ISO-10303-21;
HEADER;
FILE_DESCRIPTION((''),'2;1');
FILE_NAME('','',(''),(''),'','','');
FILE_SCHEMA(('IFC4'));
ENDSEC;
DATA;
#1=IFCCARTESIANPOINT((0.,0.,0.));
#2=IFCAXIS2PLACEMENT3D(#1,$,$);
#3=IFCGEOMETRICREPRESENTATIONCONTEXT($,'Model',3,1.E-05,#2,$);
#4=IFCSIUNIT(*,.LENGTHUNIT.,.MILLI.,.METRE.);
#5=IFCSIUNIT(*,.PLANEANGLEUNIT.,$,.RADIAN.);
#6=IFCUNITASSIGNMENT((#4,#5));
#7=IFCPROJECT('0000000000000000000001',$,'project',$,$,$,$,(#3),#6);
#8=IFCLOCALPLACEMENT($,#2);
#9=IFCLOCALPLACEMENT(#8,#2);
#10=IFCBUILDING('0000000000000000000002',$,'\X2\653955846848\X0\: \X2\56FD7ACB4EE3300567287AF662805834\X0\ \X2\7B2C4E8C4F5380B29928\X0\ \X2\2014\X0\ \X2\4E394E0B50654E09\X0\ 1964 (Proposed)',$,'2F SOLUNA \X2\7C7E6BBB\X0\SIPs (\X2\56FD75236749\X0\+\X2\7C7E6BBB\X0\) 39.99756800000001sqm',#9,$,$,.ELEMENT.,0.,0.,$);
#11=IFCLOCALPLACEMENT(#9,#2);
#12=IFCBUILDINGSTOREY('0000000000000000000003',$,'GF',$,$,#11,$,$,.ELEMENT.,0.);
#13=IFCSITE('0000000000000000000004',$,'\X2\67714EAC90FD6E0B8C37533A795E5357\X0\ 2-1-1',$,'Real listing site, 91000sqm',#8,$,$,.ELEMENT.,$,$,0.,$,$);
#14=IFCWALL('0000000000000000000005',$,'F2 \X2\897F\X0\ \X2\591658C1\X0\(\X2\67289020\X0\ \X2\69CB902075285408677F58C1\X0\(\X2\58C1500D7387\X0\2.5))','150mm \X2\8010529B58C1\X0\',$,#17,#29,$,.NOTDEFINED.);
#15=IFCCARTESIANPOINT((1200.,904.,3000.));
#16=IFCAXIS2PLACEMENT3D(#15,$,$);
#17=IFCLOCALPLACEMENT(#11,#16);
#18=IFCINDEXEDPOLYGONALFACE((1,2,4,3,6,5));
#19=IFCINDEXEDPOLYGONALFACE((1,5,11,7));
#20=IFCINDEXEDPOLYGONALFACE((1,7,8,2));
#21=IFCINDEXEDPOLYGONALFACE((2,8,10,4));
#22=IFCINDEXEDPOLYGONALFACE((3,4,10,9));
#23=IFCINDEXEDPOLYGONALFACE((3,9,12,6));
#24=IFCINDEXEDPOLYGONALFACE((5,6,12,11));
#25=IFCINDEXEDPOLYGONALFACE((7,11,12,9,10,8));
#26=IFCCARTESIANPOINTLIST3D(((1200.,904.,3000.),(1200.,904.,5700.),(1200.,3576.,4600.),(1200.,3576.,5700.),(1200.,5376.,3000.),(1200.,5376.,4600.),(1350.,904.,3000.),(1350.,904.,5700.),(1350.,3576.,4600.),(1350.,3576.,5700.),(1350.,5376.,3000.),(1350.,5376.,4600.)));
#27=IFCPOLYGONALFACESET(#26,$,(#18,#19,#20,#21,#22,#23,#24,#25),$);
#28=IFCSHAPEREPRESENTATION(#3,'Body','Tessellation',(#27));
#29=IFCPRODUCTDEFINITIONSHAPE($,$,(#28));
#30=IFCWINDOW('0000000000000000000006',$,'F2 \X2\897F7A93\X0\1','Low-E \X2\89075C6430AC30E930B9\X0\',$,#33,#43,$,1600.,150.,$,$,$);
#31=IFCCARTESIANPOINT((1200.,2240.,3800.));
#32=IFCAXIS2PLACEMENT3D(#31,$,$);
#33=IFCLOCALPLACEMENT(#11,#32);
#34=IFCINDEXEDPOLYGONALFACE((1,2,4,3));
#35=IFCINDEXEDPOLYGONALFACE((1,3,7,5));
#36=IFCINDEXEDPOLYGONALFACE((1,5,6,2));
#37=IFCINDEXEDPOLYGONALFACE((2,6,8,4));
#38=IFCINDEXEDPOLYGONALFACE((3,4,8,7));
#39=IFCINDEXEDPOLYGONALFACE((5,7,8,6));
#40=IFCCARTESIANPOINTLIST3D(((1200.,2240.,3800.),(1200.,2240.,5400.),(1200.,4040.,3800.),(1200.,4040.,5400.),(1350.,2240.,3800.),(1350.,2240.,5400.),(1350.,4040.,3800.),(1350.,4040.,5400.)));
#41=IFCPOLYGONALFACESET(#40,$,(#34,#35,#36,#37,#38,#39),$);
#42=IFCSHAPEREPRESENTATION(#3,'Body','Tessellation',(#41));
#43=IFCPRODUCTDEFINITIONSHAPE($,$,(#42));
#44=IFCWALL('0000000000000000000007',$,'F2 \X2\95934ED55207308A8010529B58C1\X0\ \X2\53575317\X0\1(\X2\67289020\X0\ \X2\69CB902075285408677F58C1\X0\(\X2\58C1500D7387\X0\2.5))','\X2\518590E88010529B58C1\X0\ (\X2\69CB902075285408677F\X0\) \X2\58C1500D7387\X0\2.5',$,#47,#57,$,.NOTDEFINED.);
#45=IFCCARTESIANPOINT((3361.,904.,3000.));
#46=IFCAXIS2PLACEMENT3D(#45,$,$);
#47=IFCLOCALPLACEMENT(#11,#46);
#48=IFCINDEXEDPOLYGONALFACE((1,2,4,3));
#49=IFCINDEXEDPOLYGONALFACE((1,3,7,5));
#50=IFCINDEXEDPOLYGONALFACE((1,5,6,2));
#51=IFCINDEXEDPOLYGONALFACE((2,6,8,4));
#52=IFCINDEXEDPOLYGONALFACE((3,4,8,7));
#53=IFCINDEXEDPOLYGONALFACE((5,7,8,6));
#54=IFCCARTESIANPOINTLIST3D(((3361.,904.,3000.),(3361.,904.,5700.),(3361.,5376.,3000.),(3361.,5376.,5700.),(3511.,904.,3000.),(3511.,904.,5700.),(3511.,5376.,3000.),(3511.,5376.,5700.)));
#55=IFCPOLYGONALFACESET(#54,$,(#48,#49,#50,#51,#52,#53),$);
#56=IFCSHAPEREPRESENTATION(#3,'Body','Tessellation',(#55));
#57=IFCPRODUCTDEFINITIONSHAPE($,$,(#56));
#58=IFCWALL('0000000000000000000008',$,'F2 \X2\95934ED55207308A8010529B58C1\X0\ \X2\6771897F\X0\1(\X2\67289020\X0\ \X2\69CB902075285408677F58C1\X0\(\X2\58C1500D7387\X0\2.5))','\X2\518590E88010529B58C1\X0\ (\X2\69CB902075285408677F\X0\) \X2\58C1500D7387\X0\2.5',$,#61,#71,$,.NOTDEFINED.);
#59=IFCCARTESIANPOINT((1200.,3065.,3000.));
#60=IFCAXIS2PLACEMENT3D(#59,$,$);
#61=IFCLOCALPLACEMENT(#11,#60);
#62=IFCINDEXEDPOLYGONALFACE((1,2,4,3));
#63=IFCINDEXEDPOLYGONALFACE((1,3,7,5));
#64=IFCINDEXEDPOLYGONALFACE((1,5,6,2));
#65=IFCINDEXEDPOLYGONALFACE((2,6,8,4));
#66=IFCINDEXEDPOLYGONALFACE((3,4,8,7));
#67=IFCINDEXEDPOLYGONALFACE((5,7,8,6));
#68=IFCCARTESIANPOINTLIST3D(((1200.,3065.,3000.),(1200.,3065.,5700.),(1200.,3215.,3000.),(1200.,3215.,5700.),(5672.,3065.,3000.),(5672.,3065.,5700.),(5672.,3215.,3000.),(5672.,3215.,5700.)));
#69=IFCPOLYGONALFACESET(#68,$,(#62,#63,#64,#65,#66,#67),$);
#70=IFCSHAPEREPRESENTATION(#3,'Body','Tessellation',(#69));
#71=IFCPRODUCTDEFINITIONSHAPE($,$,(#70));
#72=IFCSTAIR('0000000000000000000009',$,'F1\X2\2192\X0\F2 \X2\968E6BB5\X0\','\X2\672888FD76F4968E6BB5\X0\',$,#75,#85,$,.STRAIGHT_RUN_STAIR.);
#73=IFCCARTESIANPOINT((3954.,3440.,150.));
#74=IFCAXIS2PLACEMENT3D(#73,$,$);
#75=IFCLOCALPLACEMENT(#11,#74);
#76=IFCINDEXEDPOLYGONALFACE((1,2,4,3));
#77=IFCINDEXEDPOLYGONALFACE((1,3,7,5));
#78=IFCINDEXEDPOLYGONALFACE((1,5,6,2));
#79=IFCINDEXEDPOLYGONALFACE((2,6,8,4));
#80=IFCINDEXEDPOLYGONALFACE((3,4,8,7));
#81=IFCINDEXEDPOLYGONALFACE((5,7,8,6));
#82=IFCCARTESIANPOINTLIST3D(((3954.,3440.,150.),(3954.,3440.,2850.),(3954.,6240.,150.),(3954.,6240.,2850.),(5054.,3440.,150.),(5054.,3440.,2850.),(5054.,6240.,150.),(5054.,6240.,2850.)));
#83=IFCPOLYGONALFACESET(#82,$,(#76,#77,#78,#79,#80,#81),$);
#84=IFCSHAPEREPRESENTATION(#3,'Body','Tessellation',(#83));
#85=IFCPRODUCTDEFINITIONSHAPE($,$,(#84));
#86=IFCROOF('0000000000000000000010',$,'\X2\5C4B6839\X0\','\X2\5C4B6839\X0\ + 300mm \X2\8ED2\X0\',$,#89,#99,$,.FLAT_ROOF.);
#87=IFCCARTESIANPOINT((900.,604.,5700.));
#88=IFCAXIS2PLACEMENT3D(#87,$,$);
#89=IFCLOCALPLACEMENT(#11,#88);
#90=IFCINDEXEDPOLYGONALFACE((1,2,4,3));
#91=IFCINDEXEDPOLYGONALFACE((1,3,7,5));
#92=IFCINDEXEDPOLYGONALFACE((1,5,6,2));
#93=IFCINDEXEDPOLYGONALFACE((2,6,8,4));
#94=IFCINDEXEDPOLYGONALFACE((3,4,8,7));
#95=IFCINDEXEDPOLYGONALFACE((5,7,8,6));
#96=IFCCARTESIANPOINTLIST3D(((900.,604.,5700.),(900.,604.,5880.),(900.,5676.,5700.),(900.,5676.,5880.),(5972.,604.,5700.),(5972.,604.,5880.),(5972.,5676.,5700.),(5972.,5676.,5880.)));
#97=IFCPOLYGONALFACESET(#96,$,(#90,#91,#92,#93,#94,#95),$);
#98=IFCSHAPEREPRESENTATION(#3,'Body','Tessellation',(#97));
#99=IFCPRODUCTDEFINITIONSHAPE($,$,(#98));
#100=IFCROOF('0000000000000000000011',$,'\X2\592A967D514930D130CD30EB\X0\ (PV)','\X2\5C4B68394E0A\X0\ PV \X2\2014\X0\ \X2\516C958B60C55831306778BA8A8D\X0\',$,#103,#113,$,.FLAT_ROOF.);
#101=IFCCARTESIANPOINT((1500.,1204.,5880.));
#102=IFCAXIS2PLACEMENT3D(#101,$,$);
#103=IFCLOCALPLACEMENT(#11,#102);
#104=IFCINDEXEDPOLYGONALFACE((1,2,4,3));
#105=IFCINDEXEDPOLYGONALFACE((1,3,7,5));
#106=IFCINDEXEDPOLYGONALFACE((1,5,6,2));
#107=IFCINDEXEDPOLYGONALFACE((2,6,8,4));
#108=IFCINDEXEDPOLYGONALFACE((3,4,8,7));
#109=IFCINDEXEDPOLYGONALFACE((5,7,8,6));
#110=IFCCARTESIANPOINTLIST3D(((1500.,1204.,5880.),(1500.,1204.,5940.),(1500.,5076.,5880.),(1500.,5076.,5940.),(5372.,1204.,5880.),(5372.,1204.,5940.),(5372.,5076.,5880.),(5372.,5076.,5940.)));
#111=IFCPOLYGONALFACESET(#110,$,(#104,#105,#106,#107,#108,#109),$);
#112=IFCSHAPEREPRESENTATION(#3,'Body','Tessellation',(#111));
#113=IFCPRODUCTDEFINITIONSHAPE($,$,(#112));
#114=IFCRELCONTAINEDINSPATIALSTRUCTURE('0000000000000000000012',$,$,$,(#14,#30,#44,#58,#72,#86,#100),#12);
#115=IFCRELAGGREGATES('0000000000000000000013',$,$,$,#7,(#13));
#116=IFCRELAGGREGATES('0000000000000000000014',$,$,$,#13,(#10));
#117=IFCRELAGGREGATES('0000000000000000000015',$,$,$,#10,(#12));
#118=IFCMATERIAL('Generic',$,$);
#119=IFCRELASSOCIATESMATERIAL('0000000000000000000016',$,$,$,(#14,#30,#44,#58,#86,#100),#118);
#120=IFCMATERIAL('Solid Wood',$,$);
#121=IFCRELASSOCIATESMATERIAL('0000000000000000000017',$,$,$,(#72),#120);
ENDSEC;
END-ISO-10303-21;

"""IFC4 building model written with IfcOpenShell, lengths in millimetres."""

from ifc_helpers import new_model, si_unit, frame, frame_2d, origin, place, context, project, spatial, rectangle, extrude, material, element, fill, save


model = new_model("IFC4")

# Units and contexts
model_context = context("Model", 3, precision=1e-05, world=origin())
ifc_project = project(units=[si_unit("LENGTHUNIT", "METRE", prefix="MILLI"), si_unit("PLANEANGLEUNIT", "RADIAN")], contexts=[model_context])

# Site, building, storey
site_placement = place(None, origin())
site = spatial("IfcSite", under=ifc_project, at=site_placement, Name="東京都渋谷区神南 2-1-1", ObjectType="Real listing site, 91000sqm", CompositionType="ELEMENT", RefElevation=0.0)
building_placement = place(site_placement, origin())
building = spatial("IfcBuilding", under=site, at=building_placement, Name="改善案: 国立代々木競技場 第二体育館 — 丹下健三 1964 (Proposed)", ObjectType="2F SOLUNA 籾殻SIPs (国産杉+籾殻) 39.99756800000001sqm", CompositionType="ELEMENT", ElevationOfRefHeight=0.0, ElevationOfTerrain=0.0)
storey_placement = place(building_placement, origin())
storey = spatial("IfcBuildingStorey", under=building, at=storey_placement, Name="GF", CompositionType="ELEMENT", Elevation=0.0)

# Shared definitions
ifc_material_1 = material(Name="Generic")

# Shared definitions
ifc_material_2 = material(Name="Solid Wood")

# Wall, opening, window
wall_1_placement = place(storey_placement, frame((1200.0, 904.0, 3000.0)))
wall_1 = element("IfcWall", 1, at=wall_1_placement, inside=storey, material=ifc_material_1, Name="F2 西 外壁(木造 構造用合板壁(壁倍率2.5))", Description="150mm 耐力壁", PredefinedType="NOTDEFINED", context=model_context, shape_type="SweptSolid", body=[
    extrude(rectangle(XDim=150.0, YDim=4472.0, at=frame_2d((75.0, 2236.0))), frame((1200.0, 904.0, 3000.0)), (0.0, 0.0, 1.0), 2700.0),
])
opening_1_placement = place(storey_placement, frame((1200.0, 2240.0, 3800.0)))
opening_1 = element("IfcOpeningElement", 2, at=opening_1_placement, cuts=wall_1, PredefinedType="NOTDEFINED", context=model_context, shape_type="SweptSolid", body=[
    extrude(rectangle(XDim=150.0, YDim=1800.0, at=frame_2d((75.0, 900.0))), frame((1200.0, 2240.0, 3800.0)), (0.0, 0.0, 1.0), 1600.0),
])
window_1_placement = place(storey_placement, frame((1200.0, 2240.0, 3800.0)))
window_1 = element("IfcWindow", 3, at=window_1_placement, inside=storey, material=ifc_material_1, Name="F2 西窓1", Description="Low-E 複層ガラス", OverallHeight=1600.0, OverallWidth=150.0, context=model_context, shape_type="SweptSolid", body=[
    extrude(rectangle(XDim=150.0, YDim=1800.0, at=frame_2d((75.0, 900.0))), frame((1200.0, 2240.0, 3800.0)), (0.0, 0.0, 1.0), 1600.0),
])
fill(opening_1, window_1)

# Walls
wall_2_placement = place(storey_placement, frame((3361.0, 904.0, 3000.0)))
element("IfcWall", 4, at=wall_2_placement, inside=storey, material=ifc_material_1, Name="F2 間仕切り耐力壁 南北1(木造 構造用合板壁(壁倍率2.5))", Description="内部耐力壁 (構造用合板) 壁倍率2.5", PredefinedType="NOTDEFINED", context=model_context, shape_type="SweptSolid", body=[
    extrude(rectangle(XDim=150.0, YDim=4472.0, at=frame_2d((75.0, 2236.0))), frame((3361.0, 904.0, 3000.0)), (0.0, 0.0, 1.0), 2700.0),
])
wall_3_placement = place(storey_placement, frame((1200.0, 3065.0, 3000.0)))
element("IfcWall", 5, at=wall_3_placement, inside=storey, material=ifc_material_1, Name="F2 間仕切り耐力壁 東西1(木造 構造用合板壁(壁倍率2.5))", Description="内部耐力壁 (構造用合板) 壁倍率2.5", PredefinedType="NOTDEFINED", context=model_context, shape_type="SweptSolid", body=[
    extrude(rectangle(XDim=4472.0, YDim=150.0, at=frame_2d((2236.0, 75.0))), frame((1200.0, 3065.0, 3000.0)), (0.0, 0.0, 1.0), 2700.0),
])

# Stair
stair_placement = place(storey_placement, frame((3954.0, 3440.0, 150.0)))
element("IfcStair", 6, at=stair_placement, inside=storey, material=ifc_material_2, Name="F1→F2 階段", Description="木製直階段", PredefinedType="STRAIGHT_RUN_STAIR", context=model_context, shape_type="SweptSolid", body=[
    extrude(rectangle(XDim=1100.0, YDim=2800.0, at=frame_2d((550.0, 1400.0))), frame((3954.0, 3440.0, 150.0)), (0.0, 0.0, 1.0), 2700.0),
])

# Roofs
roof_1_placement = place(storey_placement, frame((900.0, 604.0, 5700.0)))
element("IfcRoof", 7, at=roof_1_placement, inside=storey, material=ifc_material_1, Name="屋根", Description="屋根 + 300mm 軒", PredefinedType="FLAT_ROOF", context=model_context, shape_type="SweptSolid", body=[
    extrude(rectangle(XDim=5072.0, YDim=5072.0, at=frame_2d((2536.0, 2536.0))), frame((900.0, 604.0, 5700.0)), (0.0, 0.0, 1.0), 180.0),
])
roof_2_placement = place(storey_placement, frame((1500.0, 1204.0, 5880.0)))
element("IfcRoof", 8, at=roof_2_placement, inside=storey, material=ifc_material_1, Name="太陽光パネル (PV)", Description="屋根上 PV — 公開情報で確認", PredefinedType="FLAT_ROOF", context=model_context, shape_type="SweptSolid", body=[
    extrude(rectangle(XDim=3872.0, YDim=3872.0, at=frame_2d((1936.0, 1936.0))), frame((1500.0, 1204.0, 5880.0)), (0.0, 0.0, 1.0), 60.0),
])

save(model, "model.ifc")
